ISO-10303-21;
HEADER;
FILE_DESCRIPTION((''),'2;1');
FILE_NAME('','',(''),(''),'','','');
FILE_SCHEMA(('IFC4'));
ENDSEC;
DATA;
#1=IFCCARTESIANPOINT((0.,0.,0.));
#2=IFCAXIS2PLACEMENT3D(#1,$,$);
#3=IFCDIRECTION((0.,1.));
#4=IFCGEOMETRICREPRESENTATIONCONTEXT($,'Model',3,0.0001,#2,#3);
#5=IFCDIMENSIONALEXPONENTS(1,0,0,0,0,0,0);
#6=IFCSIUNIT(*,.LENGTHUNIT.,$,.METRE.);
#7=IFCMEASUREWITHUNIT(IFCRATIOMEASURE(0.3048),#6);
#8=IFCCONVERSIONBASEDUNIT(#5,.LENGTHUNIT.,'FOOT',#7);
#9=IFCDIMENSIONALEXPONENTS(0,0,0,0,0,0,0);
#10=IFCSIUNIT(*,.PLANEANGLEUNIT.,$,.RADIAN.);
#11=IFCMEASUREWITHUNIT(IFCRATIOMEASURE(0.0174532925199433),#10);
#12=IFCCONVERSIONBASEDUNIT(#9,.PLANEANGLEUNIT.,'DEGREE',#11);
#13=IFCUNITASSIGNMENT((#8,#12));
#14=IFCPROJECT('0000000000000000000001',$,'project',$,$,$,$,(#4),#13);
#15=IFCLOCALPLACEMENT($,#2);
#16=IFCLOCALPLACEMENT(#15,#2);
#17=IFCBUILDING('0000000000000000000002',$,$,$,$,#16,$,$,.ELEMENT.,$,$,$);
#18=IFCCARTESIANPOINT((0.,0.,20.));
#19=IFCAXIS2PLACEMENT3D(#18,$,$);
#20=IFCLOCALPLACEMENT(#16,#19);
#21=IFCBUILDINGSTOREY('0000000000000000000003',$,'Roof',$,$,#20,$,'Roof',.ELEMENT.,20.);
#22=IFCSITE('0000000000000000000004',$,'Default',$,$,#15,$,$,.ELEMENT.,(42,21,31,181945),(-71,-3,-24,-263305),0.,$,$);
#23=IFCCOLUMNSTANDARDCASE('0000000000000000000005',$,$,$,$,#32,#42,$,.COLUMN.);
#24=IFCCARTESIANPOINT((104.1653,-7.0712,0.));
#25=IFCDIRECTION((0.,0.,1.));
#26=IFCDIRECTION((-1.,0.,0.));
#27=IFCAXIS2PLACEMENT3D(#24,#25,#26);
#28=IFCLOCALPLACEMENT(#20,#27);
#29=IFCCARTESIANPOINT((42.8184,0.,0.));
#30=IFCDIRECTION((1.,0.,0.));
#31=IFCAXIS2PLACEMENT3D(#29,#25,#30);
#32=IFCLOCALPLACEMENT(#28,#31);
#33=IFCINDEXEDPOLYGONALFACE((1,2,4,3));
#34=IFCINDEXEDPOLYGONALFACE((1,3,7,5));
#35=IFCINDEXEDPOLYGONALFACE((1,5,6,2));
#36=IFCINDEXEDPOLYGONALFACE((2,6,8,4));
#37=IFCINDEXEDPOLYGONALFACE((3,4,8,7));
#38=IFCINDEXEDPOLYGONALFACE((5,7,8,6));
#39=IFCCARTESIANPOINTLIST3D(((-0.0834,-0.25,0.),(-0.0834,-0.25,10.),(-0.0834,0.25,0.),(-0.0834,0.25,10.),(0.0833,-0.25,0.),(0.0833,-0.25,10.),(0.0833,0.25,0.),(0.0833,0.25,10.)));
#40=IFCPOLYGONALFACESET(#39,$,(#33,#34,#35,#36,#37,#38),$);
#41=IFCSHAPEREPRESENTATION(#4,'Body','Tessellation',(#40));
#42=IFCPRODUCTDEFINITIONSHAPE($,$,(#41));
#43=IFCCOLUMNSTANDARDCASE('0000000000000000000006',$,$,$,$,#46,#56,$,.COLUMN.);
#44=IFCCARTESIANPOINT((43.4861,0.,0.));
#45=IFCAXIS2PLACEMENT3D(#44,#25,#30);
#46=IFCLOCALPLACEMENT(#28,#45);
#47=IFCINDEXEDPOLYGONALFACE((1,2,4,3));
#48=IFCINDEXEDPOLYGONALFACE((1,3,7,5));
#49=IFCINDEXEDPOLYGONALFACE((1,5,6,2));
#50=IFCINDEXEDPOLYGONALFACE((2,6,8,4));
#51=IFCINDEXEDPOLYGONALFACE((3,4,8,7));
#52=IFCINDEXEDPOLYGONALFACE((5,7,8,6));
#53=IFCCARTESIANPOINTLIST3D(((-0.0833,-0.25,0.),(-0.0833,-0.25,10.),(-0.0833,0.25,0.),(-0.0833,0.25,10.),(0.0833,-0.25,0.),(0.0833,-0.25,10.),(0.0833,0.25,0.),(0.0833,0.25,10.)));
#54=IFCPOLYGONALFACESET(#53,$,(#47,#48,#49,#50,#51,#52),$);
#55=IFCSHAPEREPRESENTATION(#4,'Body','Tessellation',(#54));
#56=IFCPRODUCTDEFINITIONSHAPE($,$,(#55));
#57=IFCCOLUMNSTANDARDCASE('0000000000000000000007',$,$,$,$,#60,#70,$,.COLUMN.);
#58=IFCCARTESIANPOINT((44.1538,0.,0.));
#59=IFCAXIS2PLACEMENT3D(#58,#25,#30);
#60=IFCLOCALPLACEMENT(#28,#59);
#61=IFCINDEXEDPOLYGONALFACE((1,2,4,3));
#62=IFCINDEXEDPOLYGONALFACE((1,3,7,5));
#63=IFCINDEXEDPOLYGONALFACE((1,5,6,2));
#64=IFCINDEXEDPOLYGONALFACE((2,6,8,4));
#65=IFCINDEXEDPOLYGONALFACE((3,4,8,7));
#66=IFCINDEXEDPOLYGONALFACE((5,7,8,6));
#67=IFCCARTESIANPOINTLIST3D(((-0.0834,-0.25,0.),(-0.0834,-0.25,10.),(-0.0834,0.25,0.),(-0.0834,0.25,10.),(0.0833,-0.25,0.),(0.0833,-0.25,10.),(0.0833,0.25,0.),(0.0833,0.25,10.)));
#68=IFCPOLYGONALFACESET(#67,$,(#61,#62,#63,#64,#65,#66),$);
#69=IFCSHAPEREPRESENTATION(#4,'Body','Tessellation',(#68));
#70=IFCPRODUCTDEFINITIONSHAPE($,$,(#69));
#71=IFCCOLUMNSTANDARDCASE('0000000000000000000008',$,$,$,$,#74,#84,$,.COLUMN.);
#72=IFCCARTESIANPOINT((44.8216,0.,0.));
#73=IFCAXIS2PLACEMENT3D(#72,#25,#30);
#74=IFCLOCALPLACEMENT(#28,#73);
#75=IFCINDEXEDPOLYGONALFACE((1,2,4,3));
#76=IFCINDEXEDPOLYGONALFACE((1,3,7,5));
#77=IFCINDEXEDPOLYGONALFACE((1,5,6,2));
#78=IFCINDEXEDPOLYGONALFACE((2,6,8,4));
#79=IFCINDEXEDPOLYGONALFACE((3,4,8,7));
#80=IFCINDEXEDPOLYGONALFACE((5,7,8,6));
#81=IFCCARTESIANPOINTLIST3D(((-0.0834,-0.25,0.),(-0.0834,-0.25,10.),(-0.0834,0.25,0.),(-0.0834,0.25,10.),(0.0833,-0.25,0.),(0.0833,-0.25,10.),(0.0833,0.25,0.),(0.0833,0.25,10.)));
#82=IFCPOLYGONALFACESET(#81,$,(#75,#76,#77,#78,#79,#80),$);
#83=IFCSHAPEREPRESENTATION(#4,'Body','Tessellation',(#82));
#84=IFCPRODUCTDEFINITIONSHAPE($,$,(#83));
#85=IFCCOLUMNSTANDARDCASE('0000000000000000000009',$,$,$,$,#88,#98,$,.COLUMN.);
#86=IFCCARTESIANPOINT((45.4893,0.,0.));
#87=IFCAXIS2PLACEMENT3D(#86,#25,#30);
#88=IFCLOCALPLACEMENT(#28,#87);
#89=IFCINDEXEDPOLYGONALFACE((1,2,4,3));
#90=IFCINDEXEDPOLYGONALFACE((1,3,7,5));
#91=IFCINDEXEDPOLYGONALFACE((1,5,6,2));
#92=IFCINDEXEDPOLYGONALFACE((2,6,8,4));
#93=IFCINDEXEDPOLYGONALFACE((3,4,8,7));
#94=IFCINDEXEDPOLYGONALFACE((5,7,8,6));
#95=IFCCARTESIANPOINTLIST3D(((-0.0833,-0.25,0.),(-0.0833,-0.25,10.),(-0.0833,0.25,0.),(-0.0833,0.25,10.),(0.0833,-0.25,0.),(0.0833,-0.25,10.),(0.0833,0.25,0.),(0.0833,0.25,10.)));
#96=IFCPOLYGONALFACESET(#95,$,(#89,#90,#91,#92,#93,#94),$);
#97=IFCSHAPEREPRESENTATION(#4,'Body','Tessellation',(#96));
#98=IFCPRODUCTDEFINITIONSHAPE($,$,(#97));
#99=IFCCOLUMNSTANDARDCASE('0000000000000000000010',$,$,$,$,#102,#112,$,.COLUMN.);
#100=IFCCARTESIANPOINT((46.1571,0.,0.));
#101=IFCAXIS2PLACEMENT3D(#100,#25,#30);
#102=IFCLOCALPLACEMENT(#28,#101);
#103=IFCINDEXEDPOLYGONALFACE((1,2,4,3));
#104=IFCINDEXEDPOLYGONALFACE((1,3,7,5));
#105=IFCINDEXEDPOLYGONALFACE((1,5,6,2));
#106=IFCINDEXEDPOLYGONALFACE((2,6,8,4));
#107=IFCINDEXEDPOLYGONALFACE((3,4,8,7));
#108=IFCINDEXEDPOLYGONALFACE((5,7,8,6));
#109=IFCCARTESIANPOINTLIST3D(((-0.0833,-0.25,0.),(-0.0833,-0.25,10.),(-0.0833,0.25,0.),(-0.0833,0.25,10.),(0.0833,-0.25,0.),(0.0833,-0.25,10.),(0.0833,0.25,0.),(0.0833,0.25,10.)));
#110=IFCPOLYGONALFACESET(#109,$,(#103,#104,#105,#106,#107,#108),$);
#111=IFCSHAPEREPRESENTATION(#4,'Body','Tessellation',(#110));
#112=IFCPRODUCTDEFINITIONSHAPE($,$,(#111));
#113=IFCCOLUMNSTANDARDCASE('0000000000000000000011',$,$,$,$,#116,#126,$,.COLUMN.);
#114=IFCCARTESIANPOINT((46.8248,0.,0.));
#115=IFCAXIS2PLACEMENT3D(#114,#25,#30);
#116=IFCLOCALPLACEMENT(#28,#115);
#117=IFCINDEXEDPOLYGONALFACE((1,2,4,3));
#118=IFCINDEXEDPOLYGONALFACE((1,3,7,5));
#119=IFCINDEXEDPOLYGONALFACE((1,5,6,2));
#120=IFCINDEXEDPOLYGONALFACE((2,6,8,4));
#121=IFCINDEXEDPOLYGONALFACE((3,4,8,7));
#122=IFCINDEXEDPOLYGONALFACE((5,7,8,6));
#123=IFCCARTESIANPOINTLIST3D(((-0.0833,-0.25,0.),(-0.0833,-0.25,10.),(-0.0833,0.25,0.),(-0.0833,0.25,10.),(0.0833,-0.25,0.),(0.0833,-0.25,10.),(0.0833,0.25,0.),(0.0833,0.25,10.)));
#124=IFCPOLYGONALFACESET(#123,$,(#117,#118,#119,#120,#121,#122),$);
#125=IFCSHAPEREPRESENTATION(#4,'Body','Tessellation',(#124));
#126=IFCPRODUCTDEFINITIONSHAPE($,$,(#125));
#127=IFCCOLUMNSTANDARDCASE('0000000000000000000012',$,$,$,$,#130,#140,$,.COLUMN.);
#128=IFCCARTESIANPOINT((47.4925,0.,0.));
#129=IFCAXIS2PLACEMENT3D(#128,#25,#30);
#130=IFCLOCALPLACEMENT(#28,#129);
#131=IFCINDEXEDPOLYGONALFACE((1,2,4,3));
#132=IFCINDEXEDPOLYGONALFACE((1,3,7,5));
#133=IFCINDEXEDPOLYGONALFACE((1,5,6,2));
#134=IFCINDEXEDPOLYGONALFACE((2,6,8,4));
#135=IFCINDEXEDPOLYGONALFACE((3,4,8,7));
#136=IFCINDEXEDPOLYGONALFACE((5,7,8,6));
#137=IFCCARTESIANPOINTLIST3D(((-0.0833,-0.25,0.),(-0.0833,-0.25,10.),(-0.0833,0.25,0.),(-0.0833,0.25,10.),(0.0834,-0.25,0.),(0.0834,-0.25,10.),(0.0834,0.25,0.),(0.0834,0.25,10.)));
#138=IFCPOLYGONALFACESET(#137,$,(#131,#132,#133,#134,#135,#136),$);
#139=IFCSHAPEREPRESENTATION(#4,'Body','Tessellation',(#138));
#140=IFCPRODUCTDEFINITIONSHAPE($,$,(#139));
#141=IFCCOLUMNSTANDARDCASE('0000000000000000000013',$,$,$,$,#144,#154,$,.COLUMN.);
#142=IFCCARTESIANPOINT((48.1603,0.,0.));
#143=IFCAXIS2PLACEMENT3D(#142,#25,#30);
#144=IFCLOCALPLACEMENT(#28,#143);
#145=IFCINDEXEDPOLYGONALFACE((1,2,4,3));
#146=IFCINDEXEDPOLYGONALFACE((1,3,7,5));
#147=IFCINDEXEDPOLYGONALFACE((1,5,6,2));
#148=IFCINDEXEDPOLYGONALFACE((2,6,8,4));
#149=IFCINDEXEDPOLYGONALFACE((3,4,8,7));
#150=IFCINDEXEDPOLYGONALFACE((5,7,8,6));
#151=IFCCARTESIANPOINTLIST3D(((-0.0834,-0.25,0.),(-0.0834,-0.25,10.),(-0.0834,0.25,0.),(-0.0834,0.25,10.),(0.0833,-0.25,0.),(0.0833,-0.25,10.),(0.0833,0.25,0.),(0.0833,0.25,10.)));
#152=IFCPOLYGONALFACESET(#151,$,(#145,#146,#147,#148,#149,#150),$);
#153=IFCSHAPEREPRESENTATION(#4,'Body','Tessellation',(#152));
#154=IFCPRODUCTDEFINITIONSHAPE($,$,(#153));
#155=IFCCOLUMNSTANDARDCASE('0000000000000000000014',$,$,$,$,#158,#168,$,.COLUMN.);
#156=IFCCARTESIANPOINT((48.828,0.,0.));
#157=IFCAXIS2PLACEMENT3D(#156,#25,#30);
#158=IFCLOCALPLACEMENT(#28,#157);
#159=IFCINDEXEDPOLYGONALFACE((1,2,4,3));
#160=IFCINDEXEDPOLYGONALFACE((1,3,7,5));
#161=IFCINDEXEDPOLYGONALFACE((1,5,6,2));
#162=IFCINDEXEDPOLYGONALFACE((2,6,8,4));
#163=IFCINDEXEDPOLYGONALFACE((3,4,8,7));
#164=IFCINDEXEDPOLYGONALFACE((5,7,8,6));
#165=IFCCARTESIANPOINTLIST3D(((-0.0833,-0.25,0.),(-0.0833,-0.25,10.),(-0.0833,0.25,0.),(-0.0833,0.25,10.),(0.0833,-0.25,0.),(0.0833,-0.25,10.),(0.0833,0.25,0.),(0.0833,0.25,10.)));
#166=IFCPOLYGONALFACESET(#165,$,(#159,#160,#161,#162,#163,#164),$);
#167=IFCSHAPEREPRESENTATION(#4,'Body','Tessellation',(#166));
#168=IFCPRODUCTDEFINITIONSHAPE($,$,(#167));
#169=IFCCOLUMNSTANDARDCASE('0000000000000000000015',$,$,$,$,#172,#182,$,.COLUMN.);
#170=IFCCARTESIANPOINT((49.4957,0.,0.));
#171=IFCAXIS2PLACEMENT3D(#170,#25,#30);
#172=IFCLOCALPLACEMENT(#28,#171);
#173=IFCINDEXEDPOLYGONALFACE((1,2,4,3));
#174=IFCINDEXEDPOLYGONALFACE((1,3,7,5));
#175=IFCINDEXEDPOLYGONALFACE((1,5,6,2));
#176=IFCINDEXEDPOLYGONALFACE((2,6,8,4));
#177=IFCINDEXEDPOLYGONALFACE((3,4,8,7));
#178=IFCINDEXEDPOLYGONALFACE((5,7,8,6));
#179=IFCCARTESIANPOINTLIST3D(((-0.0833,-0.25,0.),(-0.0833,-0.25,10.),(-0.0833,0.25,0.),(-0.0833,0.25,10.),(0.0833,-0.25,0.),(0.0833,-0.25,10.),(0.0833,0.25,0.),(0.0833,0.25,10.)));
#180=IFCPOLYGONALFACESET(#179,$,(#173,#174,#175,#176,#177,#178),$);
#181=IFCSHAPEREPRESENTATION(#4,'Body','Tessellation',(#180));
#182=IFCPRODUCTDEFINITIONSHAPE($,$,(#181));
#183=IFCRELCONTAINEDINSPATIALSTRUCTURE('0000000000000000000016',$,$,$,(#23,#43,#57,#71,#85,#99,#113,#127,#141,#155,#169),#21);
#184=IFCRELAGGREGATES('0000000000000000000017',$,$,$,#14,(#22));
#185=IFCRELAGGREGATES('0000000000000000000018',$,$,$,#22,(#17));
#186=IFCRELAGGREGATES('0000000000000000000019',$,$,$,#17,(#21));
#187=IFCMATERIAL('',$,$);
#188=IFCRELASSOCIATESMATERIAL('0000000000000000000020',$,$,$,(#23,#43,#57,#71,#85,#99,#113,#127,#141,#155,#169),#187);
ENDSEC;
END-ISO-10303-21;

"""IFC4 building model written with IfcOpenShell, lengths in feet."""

from ifc_helpers import new_model, entity, si_unit, converted_unit, direction, frame, origin, place, context, project, spatial, rectangle, extrude, material, element, save


model = new_model("IFC4")

# Units and contexts
model_context = context("Model", 3, precision=0.0001, world=origin(), true_north=direction((0.0, 1.0)))
ifc_project = project(units=[converted_unit("LENGTHUNIT", "FOOT", entity("IfcRatioMeasure", 0.3048), si_unit("LENGTHUNIT", "METRE"), dimensions=[1, 0, 0, 0, 0, 0, 0]), converted_unit("PLANEANGLEUNIT", "DEGREE", entity("IfcRatioMeasure", 0.0174532925199433), si_unit("PLANEANGLEUNIT", "RADIAN"), dimensions=[0, 0, 0, 0, 0, 0, 0])], contexts=[model_context])

# Site, building, storey
site_placement = place(None, origin())
site = spatial("IfcSite", under=ifc_project, at=site_placement, Name="Default", CompositionType="ELEMENT", RefLatitude=(42, 21, 31, 181945), RefLongitude=(-71, -3, -24, -263305), RefElevation=0.0)
building_placement = place(site_placement, origin())
building = spatial("IfcBuilding", under=site, at=building_placement, CompositionType="ELEMENT")
storey_placement = place(building_placement, frame((0.0, 0.0, 20.0)))
storey = spatial("IfcBuildingStorey", under=building, at=storey_placement, Name="Roof", LongName="Roof", CompositionType="ELEMENT", Elevation=20.0)

# Columns
ifc_material = material(Name="")
placement = place(storey_placement, frame((104.1653, -7.0712, 0.0), z_axis=(0.0, 0.0, 1.0), x_axis=(-1.0, 0.0, 0.0)))
for number, where, z_axis, x_axis in (
    (1, (42.8184, 0.0, 0.0), (0.0, 0.0, 1.0), (1.0, 0.0, 0.0)),
    (2, (43.4861, 0.0, 0.0), (0.0, 0.0, 1.0), (1.0, 0.0, 0.0)),
    (3, (44.1538, 0.0, 0.0), (0.0, 0.0, 1.0), (1.0, 0.0, 0.0)),
    (4, (44.8216, 0.0, 0.0), (0.0, 0.0, 1.0), (1.0, 0.0, 0.0)),
    (5, (45.4893, 0.0, 0.0), (0.0, 0.0, 1.0), (1.0, 0.0, 0.0)),
    (6, (46.1571, 0.0, 0.0), (0.0, 0.0, 1.0), (1.0, 0.0, 0.0)),
    (7, (46.8248, 0.0, 0.0), (0.0, 0.0, 1.0), (1.0, 0.0, 0.0)),
    (8, (47.4925, 0.0, 0.0), (0.0, 0.0, 1.0), (1.0, 0.0, 0.0)),
    (9, (48.1603, 0.0, 0.0), (0.0, 0.0, 1.0), (1.0, 0.0, 0.0)),
    (10, (48.828, 0.0, 0.0), (0.0, 0.0, 1.0), (1.0, 0.0, 0.0)),
    (11, (49.4957, 0.0, 0.0), (0.0, 0.0, 1.0), (1.0, 0.0, 0.0)),
):
    element("IfcColumnStandardCase", number, at=place(placement, frame(where, z_axis=z_axis, x_axis=x_axis)), inside=storey, material=ifc_material, PredefinedType="COLUMN", context=model_context, shape_type="SweptSolid", body=[
        extrude(rectangle(XDim=0.1667, YDim=0.5), origin(), (0.0, 0.0, 1.0), 10.0),
    ])

save(model, "model.ifc")
